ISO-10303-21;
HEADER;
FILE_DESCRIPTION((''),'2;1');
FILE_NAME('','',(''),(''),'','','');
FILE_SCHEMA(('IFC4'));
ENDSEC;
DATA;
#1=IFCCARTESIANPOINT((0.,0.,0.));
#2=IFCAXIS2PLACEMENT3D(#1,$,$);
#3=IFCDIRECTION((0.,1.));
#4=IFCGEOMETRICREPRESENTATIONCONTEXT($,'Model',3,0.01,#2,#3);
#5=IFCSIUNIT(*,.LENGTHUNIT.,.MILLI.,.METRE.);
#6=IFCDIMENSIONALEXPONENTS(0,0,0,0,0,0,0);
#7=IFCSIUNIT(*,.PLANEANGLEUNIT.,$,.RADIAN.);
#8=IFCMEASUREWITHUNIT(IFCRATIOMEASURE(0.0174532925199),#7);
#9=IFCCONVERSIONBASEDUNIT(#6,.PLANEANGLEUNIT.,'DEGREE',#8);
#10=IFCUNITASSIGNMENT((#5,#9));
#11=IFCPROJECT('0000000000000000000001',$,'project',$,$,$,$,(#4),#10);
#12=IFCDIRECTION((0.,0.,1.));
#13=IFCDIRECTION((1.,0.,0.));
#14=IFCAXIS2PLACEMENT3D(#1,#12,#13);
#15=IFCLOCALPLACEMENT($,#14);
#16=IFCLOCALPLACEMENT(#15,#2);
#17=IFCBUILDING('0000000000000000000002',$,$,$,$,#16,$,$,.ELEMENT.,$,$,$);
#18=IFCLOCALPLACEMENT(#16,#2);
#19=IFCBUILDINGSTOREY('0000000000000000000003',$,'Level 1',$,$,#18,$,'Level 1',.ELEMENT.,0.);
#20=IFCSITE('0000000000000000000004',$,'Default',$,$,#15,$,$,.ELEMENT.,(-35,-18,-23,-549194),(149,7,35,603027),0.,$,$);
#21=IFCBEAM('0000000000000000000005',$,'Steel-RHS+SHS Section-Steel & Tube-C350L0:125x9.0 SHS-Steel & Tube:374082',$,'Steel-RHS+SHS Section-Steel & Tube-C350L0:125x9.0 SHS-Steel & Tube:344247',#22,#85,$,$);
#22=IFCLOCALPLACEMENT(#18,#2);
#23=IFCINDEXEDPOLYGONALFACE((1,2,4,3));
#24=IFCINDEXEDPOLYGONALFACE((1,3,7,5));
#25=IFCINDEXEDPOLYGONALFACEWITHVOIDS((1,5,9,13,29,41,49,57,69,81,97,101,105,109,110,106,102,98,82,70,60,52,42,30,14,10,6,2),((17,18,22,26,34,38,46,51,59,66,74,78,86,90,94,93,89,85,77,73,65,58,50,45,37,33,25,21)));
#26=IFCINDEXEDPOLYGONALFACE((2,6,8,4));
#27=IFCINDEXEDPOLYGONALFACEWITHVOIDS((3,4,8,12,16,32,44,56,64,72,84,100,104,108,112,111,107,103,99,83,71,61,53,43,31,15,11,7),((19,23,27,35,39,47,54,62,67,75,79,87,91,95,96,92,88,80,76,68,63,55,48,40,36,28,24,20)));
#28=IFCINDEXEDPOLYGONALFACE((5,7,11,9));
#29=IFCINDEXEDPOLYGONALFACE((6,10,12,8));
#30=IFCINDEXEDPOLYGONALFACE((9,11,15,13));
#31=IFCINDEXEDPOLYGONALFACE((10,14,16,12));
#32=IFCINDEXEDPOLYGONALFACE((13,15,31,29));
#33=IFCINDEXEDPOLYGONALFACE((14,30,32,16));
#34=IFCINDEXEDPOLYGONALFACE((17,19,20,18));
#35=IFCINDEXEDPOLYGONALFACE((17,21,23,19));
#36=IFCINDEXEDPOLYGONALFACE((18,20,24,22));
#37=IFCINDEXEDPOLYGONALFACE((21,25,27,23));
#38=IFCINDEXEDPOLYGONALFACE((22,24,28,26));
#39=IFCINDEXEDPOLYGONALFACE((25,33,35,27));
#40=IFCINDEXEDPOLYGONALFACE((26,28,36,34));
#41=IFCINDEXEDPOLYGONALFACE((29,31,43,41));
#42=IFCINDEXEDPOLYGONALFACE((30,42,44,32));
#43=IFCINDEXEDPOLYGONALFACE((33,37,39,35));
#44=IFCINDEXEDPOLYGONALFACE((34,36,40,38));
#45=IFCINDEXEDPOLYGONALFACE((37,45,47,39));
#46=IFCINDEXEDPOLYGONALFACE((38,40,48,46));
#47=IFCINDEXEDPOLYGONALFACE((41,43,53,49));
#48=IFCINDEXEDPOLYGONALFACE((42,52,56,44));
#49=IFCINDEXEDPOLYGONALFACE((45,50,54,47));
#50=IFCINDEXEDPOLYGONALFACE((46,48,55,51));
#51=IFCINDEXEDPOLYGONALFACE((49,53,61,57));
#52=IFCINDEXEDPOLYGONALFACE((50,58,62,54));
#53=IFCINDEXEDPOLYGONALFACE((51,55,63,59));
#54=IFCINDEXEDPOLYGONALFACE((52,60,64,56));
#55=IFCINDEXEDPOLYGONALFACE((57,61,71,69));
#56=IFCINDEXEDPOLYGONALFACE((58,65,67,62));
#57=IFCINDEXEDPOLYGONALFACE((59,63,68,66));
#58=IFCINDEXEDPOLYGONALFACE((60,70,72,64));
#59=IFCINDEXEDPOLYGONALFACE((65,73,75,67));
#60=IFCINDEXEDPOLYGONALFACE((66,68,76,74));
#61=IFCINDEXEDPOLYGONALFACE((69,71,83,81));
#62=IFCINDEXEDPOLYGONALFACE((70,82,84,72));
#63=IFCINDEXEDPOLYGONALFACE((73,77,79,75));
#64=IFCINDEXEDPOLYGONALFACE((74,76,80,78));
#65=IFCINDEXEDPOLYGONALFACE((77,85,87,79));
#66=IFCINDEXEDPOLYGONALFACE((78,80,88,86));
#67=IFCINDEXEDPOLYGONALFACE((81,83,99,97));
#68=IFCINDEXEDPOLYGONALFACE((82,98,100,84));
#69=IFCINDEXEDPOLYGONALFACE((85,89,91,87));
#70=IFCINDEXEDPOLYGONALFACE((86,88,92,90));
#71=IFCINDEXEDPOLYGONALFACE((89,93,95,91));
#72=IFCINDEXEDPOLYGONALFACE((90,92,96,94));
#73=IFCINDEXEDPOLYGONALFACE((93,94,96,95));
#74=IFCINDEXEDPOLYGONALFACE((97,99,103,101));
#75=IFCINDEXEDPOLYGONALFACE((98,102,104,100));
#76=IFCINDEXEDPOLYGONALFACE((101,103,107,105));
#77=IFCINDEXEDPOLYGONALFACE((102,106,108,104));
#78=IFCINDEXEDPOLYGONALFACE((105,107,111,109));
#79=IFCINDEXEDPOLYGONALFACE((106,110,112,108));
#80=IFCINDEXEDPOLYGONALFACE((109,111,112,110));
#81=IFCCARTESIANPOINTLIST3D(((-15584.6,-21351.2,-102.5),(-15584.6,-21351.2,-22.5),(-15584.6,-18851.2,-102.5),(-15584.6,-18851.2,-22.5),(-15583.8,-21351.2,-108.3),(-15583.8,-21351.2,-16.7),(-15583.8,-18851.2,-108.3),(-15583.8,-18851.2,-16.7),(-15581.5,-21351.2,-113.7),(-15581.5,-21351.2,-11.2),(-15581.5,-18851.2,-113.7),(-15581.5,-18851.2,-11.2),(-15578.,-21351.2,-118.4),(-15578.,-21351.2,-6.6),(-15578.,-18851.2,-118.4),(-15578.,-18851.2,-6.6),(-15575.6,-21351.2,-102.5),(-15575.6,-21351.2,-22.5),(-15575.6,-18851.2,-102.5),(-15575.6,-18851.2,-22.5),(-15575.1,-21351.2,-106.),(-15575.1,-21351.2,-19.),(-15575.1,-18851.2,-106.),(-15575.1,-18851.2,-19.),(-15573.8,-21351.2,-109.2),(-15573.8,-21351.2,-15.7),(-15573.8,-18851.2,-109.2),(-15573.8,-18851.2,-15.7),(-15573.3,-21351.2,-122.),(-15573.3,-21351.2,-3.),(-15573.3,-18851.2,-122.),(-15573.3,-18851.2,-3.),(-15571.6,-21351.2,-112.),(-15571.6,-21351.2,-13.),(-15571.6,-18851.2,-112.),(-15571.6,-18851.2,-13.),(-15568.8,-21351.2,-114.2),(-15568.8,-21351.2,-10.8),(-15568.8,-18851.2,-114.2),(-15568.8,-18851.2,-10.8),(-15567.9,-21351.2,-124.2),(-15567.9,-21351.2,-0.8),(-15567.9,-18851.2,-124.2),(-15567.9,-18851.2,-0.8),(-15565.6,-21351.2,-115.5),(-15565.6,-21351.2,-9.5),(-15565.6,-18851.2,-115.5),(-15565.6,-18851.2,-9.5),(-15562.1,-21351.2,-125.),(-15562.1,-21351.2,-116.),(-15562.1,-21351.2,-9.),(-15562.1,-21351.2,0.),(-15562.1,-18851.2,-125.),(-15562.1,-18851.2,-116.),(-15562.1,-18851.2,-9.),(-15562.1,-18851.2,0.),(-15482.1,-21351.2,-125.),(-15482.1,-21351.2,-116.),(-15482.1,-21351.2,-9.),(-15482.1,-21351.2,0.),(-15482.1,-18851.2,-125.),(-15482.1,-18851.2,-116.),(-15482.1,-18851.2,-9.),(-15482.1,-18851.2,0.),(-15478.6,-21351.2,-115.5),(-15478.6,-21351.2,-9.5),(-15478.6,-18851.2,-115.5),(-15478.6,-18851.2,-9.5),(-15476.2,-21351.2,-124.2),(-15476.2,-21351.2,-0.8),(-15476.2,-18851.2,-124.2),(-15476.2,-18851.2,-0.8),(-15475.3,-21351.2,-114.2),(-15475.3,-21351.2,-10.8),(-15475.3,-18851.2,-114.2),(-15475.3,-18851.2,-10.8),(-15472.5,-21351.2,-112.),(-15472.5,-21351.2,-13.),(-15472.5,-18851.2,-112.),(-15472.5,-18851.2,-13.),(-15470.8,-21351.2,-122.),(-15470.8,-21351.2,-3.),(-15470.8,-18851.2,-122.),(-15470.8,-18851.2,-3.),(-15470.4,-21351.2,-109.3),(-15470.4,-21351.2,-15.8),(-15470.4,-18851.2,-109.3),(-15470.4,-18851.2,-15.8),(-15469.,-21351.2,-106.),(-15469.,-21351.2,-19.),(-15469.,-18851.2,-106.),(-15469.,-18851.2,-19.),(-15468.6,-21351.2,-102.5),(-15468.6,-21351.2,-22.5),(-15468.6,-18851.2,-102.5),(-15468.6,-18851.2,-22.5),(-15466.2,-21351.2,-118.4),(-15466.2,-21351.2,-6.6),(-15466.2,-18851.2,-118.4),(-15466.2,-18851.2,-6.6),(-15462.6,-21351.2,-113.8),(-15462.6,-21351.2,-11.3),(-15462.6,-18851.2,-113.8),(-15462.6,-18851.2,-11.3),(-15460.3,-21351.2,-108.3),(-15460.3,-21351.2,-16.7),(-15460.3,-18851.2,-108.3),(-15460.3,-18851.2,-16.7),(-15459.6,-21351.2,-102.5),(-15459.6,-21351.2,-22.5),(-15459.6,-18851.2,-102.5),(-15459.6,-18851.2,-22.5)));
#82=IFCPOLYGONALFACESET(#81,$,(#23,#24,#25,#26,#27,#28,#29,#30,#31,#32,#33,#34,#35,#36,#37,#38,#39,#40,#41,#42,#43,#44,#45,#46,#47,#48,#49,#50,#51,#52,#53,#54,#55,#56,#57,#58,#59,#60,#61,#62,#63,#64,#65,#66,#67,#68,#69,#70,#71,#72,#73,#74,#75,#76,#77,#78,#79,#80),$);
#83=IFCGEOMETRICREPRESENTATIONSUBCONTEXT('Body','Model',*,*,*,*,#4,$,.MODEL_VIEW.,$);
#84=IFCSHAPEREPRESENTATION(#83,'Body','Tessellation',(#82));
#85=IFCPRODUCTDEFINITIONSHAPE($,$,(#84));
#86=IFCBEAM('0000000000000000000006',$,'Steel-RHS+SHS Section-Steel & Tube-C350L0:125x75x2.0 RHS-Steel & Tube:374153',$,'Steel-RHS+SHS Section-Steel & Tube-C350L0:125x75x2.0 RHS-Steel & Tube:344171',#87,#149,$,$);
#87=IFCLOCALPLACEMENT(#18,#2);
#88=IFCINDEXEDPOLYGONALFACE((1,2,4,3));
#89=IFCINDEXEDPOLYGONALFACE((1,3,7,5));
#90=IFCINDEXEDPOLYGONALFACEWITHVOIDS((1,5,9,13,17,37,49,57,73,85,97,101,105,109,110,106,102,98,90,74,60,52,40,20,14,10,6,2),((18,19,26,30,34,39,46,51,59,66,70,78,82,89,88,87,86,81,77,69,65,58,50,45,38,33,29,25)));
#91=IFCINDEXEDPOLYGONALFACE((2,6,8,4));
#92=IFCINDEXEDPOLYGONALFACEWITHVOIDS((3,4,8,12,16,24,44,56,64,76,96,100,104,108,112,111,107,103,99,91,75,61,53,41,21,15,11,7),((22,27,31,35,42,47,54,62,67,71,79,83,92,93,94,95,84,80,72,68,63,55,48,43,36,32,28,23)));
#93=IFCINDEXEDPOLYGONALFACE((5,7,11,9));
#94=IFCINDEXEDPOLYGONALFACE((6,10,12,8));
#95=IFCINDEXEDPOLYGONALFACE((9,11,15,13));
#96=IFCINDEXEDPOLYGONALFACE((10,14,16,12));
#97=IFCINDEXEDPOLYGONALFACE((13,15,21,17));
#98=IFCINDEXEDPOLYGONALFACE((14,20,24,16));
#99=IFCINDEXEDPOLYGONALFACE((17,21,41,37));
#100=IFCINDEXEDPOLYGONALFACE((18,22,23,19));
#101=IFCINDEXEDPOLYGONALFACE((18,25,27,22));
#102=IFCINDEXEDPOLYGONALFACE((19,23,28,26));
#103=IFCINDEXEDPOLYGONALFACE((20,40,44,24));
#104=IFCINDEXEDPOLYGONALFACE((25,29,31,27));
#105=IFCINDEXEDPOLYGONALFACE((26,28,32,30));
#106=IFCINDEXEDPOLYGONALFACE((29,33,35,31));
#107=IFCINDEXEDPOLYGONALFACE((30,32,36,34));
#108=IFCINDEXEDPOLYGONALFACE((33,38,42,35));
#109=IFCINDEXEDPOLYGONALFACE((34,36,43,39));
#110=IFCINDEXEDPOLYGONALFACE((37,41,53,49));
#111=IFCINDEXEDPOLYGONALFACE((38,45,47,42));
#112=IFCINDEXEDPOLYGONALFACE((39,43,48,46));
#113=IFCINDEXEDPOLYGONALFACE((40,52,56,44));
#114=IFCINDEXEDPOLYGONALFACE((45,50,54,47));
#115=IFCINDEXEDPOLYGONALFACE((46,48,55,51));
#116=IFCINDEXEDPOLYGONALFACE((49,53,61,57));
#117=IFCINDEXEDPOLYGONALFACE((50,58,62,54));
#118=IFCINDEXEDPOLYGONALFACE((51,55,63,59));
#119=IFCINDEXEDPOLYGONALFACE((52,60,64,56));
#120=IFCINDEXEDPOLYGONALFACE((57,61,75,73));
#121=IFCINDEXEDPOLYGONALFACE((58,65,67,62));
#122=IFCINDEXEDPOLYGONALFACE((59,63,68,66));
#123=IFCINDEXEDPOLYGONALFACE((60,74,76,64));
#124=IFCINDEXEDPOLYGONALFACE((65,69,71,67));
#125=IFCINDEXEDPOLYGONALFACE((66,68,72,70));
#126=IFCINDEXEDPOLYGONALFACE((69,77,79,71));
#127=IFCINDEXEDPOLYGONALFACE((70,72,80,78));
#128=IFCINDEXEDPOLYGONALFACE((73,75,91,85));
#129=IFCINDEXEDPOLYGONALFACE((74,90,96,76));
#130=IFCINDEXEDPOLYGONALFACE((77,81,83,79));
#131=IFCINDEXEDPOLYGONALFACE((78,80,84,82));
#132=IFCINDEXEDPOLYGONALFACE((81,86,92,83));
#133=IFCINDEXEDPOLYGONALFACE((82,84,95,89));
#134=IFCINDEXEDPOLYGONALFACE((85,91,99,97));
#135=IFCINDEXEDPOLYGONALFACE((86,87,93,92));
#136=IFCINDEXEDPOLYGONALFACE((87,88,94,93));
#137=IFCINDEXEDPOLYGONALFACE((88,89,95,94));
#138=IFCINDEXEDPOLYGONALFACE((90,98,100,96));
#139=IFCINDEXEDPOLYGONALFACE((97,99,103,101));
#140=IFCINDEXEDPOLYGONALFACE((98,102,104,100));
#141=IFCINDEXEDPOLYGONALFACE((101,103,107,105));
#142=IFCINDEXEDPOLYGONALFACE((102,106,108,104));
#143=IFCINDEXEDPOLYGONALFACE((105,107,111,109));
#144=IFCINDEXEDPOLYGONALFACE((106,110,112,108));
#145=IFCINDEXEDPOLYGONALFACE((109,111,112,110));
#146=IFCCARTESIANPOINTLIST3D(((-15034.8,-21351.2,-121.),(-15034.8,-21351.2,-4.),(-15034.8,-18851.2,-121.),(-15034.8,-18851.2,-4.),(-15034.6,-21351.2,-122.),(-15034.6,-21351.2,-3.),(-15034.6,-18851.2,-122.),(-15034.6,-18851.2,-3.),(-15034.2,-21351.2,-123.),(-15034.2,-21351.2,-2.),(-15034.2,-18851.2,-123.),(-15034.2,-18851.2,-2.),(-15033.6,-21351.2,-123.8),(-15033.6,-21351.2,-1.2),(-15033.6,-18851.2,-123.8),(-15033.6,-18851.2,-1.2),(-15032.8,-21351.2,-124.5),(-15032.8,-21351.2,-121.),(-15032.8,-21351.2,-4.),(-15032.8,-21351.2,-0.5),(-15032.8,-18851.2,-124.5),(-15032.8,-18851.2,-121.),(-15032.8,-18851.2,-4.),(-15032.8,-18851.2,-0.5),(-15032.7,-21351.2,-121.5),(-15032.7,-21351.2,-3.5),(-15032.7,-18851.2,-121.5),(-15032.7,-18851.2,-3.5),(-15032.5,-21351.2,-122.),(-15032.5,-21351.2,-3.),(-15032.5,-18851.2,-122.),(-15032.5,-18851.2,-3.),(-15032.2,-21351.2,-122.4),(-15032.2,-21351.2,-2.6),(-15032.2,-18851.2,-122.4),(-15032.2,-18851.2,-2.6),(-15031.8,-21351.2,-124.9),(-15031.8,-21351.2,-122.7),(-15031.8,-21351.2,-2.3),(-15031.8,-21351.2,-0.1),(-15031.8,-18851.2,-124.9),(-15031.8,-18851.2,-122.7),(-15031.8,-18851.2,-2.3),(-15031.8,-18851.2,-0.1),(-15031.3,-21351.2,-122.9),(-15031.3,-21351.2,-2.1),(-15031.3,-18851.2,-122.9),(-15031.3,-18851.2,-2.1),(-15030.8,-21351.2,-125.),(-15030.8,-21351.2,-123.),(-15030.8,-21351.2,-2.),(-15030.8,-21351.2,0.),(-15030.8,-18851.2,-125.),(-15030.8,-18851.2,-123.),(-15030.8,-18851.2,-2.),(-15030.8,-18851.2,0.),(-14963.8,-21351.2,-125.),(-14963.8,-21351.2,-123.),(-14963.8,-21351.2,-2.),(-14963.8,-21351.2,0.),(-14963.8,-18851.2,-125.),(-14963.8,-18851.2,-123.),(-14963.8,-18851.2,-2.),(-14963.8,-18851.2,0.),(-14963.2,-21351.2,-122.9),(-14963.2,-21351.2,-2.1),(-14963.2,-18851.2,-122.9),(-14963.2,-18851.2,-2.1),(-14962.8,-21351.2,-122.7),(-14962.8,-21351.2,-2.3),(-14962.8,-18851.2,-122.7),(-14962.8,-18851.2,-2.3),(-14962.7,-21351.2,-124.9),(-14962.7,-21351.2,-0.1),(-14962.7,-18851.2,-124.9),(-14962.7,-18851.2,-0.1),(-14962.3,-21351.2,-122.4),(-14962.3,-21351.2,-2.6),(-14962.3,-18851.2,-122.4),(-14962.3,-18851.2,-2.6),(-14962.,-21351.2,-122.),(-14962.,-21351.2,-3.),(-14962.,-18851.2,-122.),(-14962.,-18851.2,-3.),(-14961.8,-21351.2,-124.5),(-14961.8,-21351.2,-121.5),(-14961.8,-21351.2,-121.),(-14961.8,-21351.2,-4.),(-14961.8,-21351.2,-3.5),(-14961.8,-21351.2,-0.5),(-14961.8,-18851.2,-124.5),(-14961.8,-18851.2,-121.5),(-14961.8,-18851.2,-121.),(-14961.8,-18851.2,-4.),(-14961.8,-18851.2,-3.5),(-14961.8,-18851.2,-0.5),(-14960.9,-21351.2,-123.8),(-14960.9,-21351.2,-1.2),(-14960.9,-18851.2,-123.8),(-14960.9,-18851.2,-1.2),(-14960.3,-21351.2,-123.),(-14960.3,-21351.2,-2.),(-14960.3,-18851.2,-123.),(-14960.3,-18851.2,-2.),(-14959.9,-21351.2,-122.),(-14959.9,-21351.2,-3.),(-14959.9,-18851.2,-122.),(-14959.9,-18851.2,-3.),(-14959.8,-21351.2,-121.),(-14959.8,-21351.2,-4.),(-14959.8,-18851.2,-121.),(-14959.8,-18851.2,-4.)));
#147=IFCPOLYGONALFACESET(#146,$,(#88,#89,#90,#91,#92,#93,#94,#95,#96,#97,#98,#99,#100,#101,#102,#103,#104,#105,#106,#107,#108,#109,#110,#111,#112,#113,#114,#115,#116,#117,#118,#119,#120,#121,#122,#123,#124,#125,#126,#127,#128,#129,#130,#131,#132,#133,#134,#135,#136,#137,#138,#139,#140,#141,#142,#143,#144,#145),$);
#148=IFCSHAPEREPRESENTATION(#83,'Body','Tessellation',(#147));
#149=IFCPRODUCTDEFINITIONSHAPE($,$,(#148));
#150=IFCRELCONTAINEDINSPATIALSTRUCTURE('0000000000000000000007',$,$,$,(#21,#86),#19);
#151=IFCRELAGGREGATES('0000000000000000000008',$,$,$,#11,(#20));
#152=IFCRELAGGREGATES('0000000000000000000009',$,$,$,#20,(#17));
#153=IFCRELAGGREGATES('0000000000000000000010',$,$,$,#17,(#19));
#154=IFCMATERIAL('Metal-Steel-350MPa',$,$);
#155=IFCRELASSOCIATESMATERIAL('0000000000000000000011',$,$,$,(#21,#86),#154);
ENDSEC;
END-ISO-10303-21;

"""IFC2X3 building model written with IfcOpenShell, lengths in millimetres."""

from ifc_helpers import new_model, entity, si_unit, converted_unit, direction, frame, frame_2d, origin, origin_with_axes, place, context, subcontext, project, spatial, polyline, circle_curve, parameter, trimmed, segment, composite_curve, outline, extrude, material, element, save


model = new_model("IFC2X3")

# Units and contexts
model_context = context("Model", 3, precision=0.01, world=origin(), true_north=direction((0.0, 1.0)))
body_context = subcontext(model_context, "Body", "Model", "MODEL_VIEW")
ifc_project = project(units=[si_unit("LENGTHUNIT", "METRE", prefix="MILLI"), converted_unit("PLANEANGLEUNIT", "DEGREE", entity("IfcRatioMeasure", 0.0174532925199), si_unit("PLANEANGLEUNIT", "RADIAN"), dimensions=[0, 0, 0, 0, 0, 0, 0])], contexts=[model_context])

# Site, building, storey
site_placement = place(None, origin_with_axes())
site = spatial("IfcSite", under=ifc_project, at=site_placement, Name="Default", CompositionType="ELEMENT", RefLatitude=(-35, -18, -23, -549194), RefLongitude=(149, 7, 35, 603027), RefElevation=0.0)
building_placement = place(site_placement, origin())
building = spatial("IfcBuilding", under=site, at=building_placement, CompositionType="ELEMENT")
storey_placement = place(building_placement, origin())
storey = spatial("IfcBuildingStorey", under=building, at=storey_placement, Name="Level 1", LongName="Level 1", CompositionType="ELEMENT", Elevation=0.0)

# Beams
ifc_material = material(Name="Metal-Steel-350MPa")
beam_1_placement = place(storey_placement, frame((-15522.1, -18851.2, 0.0), z_axis=(0.0, 0.0, 1.0), x_axis=(0.0, -1.0, 0.0)))
element("IfcBeam", 1, at=beam_1_placement, inside=storey, material=ifc_material, Name="Steel-RHS+SHS Section-Steel & Tube-C350L0:125x9.0 SHS-Steel & Tube:374082", ObjectType="Steel-RHS+SHS Section-Steel & Tube-C350L0:125x9.0 SHS-Steel & Tube:344247", context=body_context, shape_type="SweptSolid", body=[
    extrude(outline(composite_curve([segment(trimmed(circle_curve(frame_2d((-40.0, -40.0), x_axis=(1.0, 0.0)), 22.5), [parameter(180.0)], [parameter(270.0)], True, "PARAMETER"), True, "CONTINUOUS"), segment(polyline([(-40.0, -62.5), (40.0, -62.5)]), True, "CONTINUOUS"), segment(trimmed(circle_curve(frame_2d((40.0, -40.0), x_axis=(1.0, 0.0)), 22.5), [parameter(270.0)], [parameter(0.0)], True, "PARAMETER"), True, "CONTINUOUS"), segment(polyline([(62.5, -40.0), (62.5, 40.0)]), True, "CONTINUOUS"), segment(trimmed(circle_curve(frame_2d((40.0, 40.0), x_axis=(1.0, 0.0)), 22.5), [parameter(0.0)], [parameter(90.0)], True, "PARAMETER"), True, "CONTINUOUS"), segment(polyline([(40.0, 62.5), (-40.0, 62.5)]), True, "CONTINUOUS"), segment(trimmed(circle_curve(frame_2d((-40.0, 40.0), x_axis=(1.0, 0.0)), 22.5), [parameter(90.0)], [parameter(180.0)], True, "PARAMETER"), True, "CONTINUOUS"), segment(polyline([(-62.5, 40.0), (-62.5, -40.0)]), True, "CONTINUOUS")], self_intersect=False), holes=[composite_curve([segment(polyline([(40.0, -53.5), (-40.0, -53.5)]), True, "CONTINUOUS"), segment(trimmed(circle_curve(frame_2d((-40.0, -40.0), x_axis=(1.0, 0.0)), 13.5), [parameter(180.0)], [parameter(270.0)], True, "PARAMETER"), False, "CONTINUOUS"), segment(polyline([(-53.5, -40.0), (-53.5, 40.0)]), True, "CONTINUOUS"), segment(trimmed(circle_curve(frame_2d((-40.0, 40.0), x_axis=(1.0, 0.0)), 13.5), [parameter(90.0)], [parameter(180.0)], True, "PARAMETER"), False, "CONTINUOUS"), segment(polyline([(-40.0, 53.5), (40.0, 53.5)]), True, "CONTINUOUS"), segment(trimmed(circle_curve(frame_2d((40.0, 40.0), x_axis=(1.0, 0.0)), 13.5), [parameter(360.0)], [parameter(90.0)], True, "PARAMETER"), False, "CONTINUOUS"), segment(polyline([(53.5, 40.0), (53.5, -40.0)]), True, "CONTINUOUS"), segment(trimmed(circle_curve(frame_2d((40.0, -40.0), x_axis=(1.0, 0.0)), 13.5), [parameter(270.0)], [parameter(0.0)], True, "PARAMETER"), False, "CONTINUOUS")], self_intersect=False)]), frame((0.0, 0.0, -62.5), z_axis=(1.0, 0.0, 0.0), x_axis=(0.0, -1.0, 0.0)), (0.0, 0.0, 1.0), 2500.0),
])
beam_2_placement = place(storey_placement, frame((-14997.3, -18851.2, 0.0), z_axis=(0.0, 0.0, 1.0), x_axis=(0.0, -1.0, 0.0)))
element("IfcBeam", 2, at=beam_2_placement, inside=storey, material=ifc_material, Name="Steel-RHS+SHS Section-Steel & Tube-C350L0:125x75x2.0 RHS-Steel & Tube:374153", ObjectType="Steel-RHS+SHS Section-Steel & Tube-C350L0:125x75x2.0 RHS-Steel & Tube:344171", context=body_context, shape_type="SweptSolid", body=[
    extrude(outline(composite_curve([segment(trimmed(circle_curve(frame_2d((-33.5, -58.5), x_axis=(1.0, 0.0)), 4.0), [parameter(180.0)], [parameter(270.0)], True, "PARAMETER"), True, "CONTINUOUS"), segment(polyline([(-33.5, -62.5), (33.5, -62.5)]), True, "CONTINUOUS"), segment(trimmed(circle_curve(frame_2d((33.5, -58.5), x_axis=(1.0, 0.0)), 4.0), [parameter(270.0)], [parameter(0.0)], True, "PARAMETER"), True, "CONTINUOUS"), segment(polyline([(37.5, -58.5), (37.5, 58.5)]), True, "CONTINUOUS"), segment(trimmed(circle_curve(frame_2d((33.5, 58.5), x_axis=(1.0, 0.0)), 4.0), [parameter(0.0)], [parameter(90.0)], True, "PARAMETER"), True, "CONTINUOUS"), segment(polyline([(33.5, 62.5), (-33.5, 62.5)]), True, "CONTINUOUS"), segment(trimmed(circle_curve(frame_2d((-33.5, 58.5), x_axis=(1.0, 0.0)), 4.0), [parameter(90.0)], [parameter(180.0)], True, "PARAMETER"), True, "CONTINUOUS"), segment(polyline([(-37.5, 58.5), (-37.5, -58.5)]), True, "CONTINUOUS")], self_intersect=False), holes=[composite_curve([segment(polyline([(33.5, -60.5), (-33.5, -60.5)]), True, "CONTINUOUS"), segment(trimmed(circle_curve(frame_2d((-33.5, -58.5), x_axis=(1.0, 0.0)), 2.0), [parameter(180.0)], [parameter(270.0)], True, "PARAMETER"), False, "CONTINUOUS"), segment(polyline([(-35.5, -58.5), (-35.5, 58.5)]), True, "CONTINUOUS"), segment(trimmed(circle_curve(frame_2d((-33.5, 58.5), x_axis=(1.0, 0.0)), 2.0), [parameter(90.0)], [parameter(180.0)], True, "PARAMETER"), False, "CONTINUOUS"), segment(polyline([(-33.5, 60.5), (33.5, 60.5)]), True, "CONTINUOUS"), segment(trimmed(circle_curve(frame_2d((33.5, 58.5), x_axis=(1.0, 0.0)), 2.0), [parameter(360.0)], [parameter(90.0)], True, "PARAMETER"), False, "CONTINUOUS"), segment(polyline([(35.5, 58.5), (35.5, -58.5)]), True, "CONTINUOUS"), segment(trimmed(circle_curve(frame_2d((33.5, -58.5), x_axis=(1.0, 0.0)), 2.0), [parameter(270.0)], [parameter(360.0)], True, "PARAMETER"), False, "CONTINUOUS")], self_intersect=False)]), frame((0.0, 0.0, -62.5), z_axis=(1.0, 0.0, 0.0), x_axis=(0.0, -1.0, 0.0)), (0.0, 0.0, 1.0), 2500.0),
])

save(model, "model.ifc")
